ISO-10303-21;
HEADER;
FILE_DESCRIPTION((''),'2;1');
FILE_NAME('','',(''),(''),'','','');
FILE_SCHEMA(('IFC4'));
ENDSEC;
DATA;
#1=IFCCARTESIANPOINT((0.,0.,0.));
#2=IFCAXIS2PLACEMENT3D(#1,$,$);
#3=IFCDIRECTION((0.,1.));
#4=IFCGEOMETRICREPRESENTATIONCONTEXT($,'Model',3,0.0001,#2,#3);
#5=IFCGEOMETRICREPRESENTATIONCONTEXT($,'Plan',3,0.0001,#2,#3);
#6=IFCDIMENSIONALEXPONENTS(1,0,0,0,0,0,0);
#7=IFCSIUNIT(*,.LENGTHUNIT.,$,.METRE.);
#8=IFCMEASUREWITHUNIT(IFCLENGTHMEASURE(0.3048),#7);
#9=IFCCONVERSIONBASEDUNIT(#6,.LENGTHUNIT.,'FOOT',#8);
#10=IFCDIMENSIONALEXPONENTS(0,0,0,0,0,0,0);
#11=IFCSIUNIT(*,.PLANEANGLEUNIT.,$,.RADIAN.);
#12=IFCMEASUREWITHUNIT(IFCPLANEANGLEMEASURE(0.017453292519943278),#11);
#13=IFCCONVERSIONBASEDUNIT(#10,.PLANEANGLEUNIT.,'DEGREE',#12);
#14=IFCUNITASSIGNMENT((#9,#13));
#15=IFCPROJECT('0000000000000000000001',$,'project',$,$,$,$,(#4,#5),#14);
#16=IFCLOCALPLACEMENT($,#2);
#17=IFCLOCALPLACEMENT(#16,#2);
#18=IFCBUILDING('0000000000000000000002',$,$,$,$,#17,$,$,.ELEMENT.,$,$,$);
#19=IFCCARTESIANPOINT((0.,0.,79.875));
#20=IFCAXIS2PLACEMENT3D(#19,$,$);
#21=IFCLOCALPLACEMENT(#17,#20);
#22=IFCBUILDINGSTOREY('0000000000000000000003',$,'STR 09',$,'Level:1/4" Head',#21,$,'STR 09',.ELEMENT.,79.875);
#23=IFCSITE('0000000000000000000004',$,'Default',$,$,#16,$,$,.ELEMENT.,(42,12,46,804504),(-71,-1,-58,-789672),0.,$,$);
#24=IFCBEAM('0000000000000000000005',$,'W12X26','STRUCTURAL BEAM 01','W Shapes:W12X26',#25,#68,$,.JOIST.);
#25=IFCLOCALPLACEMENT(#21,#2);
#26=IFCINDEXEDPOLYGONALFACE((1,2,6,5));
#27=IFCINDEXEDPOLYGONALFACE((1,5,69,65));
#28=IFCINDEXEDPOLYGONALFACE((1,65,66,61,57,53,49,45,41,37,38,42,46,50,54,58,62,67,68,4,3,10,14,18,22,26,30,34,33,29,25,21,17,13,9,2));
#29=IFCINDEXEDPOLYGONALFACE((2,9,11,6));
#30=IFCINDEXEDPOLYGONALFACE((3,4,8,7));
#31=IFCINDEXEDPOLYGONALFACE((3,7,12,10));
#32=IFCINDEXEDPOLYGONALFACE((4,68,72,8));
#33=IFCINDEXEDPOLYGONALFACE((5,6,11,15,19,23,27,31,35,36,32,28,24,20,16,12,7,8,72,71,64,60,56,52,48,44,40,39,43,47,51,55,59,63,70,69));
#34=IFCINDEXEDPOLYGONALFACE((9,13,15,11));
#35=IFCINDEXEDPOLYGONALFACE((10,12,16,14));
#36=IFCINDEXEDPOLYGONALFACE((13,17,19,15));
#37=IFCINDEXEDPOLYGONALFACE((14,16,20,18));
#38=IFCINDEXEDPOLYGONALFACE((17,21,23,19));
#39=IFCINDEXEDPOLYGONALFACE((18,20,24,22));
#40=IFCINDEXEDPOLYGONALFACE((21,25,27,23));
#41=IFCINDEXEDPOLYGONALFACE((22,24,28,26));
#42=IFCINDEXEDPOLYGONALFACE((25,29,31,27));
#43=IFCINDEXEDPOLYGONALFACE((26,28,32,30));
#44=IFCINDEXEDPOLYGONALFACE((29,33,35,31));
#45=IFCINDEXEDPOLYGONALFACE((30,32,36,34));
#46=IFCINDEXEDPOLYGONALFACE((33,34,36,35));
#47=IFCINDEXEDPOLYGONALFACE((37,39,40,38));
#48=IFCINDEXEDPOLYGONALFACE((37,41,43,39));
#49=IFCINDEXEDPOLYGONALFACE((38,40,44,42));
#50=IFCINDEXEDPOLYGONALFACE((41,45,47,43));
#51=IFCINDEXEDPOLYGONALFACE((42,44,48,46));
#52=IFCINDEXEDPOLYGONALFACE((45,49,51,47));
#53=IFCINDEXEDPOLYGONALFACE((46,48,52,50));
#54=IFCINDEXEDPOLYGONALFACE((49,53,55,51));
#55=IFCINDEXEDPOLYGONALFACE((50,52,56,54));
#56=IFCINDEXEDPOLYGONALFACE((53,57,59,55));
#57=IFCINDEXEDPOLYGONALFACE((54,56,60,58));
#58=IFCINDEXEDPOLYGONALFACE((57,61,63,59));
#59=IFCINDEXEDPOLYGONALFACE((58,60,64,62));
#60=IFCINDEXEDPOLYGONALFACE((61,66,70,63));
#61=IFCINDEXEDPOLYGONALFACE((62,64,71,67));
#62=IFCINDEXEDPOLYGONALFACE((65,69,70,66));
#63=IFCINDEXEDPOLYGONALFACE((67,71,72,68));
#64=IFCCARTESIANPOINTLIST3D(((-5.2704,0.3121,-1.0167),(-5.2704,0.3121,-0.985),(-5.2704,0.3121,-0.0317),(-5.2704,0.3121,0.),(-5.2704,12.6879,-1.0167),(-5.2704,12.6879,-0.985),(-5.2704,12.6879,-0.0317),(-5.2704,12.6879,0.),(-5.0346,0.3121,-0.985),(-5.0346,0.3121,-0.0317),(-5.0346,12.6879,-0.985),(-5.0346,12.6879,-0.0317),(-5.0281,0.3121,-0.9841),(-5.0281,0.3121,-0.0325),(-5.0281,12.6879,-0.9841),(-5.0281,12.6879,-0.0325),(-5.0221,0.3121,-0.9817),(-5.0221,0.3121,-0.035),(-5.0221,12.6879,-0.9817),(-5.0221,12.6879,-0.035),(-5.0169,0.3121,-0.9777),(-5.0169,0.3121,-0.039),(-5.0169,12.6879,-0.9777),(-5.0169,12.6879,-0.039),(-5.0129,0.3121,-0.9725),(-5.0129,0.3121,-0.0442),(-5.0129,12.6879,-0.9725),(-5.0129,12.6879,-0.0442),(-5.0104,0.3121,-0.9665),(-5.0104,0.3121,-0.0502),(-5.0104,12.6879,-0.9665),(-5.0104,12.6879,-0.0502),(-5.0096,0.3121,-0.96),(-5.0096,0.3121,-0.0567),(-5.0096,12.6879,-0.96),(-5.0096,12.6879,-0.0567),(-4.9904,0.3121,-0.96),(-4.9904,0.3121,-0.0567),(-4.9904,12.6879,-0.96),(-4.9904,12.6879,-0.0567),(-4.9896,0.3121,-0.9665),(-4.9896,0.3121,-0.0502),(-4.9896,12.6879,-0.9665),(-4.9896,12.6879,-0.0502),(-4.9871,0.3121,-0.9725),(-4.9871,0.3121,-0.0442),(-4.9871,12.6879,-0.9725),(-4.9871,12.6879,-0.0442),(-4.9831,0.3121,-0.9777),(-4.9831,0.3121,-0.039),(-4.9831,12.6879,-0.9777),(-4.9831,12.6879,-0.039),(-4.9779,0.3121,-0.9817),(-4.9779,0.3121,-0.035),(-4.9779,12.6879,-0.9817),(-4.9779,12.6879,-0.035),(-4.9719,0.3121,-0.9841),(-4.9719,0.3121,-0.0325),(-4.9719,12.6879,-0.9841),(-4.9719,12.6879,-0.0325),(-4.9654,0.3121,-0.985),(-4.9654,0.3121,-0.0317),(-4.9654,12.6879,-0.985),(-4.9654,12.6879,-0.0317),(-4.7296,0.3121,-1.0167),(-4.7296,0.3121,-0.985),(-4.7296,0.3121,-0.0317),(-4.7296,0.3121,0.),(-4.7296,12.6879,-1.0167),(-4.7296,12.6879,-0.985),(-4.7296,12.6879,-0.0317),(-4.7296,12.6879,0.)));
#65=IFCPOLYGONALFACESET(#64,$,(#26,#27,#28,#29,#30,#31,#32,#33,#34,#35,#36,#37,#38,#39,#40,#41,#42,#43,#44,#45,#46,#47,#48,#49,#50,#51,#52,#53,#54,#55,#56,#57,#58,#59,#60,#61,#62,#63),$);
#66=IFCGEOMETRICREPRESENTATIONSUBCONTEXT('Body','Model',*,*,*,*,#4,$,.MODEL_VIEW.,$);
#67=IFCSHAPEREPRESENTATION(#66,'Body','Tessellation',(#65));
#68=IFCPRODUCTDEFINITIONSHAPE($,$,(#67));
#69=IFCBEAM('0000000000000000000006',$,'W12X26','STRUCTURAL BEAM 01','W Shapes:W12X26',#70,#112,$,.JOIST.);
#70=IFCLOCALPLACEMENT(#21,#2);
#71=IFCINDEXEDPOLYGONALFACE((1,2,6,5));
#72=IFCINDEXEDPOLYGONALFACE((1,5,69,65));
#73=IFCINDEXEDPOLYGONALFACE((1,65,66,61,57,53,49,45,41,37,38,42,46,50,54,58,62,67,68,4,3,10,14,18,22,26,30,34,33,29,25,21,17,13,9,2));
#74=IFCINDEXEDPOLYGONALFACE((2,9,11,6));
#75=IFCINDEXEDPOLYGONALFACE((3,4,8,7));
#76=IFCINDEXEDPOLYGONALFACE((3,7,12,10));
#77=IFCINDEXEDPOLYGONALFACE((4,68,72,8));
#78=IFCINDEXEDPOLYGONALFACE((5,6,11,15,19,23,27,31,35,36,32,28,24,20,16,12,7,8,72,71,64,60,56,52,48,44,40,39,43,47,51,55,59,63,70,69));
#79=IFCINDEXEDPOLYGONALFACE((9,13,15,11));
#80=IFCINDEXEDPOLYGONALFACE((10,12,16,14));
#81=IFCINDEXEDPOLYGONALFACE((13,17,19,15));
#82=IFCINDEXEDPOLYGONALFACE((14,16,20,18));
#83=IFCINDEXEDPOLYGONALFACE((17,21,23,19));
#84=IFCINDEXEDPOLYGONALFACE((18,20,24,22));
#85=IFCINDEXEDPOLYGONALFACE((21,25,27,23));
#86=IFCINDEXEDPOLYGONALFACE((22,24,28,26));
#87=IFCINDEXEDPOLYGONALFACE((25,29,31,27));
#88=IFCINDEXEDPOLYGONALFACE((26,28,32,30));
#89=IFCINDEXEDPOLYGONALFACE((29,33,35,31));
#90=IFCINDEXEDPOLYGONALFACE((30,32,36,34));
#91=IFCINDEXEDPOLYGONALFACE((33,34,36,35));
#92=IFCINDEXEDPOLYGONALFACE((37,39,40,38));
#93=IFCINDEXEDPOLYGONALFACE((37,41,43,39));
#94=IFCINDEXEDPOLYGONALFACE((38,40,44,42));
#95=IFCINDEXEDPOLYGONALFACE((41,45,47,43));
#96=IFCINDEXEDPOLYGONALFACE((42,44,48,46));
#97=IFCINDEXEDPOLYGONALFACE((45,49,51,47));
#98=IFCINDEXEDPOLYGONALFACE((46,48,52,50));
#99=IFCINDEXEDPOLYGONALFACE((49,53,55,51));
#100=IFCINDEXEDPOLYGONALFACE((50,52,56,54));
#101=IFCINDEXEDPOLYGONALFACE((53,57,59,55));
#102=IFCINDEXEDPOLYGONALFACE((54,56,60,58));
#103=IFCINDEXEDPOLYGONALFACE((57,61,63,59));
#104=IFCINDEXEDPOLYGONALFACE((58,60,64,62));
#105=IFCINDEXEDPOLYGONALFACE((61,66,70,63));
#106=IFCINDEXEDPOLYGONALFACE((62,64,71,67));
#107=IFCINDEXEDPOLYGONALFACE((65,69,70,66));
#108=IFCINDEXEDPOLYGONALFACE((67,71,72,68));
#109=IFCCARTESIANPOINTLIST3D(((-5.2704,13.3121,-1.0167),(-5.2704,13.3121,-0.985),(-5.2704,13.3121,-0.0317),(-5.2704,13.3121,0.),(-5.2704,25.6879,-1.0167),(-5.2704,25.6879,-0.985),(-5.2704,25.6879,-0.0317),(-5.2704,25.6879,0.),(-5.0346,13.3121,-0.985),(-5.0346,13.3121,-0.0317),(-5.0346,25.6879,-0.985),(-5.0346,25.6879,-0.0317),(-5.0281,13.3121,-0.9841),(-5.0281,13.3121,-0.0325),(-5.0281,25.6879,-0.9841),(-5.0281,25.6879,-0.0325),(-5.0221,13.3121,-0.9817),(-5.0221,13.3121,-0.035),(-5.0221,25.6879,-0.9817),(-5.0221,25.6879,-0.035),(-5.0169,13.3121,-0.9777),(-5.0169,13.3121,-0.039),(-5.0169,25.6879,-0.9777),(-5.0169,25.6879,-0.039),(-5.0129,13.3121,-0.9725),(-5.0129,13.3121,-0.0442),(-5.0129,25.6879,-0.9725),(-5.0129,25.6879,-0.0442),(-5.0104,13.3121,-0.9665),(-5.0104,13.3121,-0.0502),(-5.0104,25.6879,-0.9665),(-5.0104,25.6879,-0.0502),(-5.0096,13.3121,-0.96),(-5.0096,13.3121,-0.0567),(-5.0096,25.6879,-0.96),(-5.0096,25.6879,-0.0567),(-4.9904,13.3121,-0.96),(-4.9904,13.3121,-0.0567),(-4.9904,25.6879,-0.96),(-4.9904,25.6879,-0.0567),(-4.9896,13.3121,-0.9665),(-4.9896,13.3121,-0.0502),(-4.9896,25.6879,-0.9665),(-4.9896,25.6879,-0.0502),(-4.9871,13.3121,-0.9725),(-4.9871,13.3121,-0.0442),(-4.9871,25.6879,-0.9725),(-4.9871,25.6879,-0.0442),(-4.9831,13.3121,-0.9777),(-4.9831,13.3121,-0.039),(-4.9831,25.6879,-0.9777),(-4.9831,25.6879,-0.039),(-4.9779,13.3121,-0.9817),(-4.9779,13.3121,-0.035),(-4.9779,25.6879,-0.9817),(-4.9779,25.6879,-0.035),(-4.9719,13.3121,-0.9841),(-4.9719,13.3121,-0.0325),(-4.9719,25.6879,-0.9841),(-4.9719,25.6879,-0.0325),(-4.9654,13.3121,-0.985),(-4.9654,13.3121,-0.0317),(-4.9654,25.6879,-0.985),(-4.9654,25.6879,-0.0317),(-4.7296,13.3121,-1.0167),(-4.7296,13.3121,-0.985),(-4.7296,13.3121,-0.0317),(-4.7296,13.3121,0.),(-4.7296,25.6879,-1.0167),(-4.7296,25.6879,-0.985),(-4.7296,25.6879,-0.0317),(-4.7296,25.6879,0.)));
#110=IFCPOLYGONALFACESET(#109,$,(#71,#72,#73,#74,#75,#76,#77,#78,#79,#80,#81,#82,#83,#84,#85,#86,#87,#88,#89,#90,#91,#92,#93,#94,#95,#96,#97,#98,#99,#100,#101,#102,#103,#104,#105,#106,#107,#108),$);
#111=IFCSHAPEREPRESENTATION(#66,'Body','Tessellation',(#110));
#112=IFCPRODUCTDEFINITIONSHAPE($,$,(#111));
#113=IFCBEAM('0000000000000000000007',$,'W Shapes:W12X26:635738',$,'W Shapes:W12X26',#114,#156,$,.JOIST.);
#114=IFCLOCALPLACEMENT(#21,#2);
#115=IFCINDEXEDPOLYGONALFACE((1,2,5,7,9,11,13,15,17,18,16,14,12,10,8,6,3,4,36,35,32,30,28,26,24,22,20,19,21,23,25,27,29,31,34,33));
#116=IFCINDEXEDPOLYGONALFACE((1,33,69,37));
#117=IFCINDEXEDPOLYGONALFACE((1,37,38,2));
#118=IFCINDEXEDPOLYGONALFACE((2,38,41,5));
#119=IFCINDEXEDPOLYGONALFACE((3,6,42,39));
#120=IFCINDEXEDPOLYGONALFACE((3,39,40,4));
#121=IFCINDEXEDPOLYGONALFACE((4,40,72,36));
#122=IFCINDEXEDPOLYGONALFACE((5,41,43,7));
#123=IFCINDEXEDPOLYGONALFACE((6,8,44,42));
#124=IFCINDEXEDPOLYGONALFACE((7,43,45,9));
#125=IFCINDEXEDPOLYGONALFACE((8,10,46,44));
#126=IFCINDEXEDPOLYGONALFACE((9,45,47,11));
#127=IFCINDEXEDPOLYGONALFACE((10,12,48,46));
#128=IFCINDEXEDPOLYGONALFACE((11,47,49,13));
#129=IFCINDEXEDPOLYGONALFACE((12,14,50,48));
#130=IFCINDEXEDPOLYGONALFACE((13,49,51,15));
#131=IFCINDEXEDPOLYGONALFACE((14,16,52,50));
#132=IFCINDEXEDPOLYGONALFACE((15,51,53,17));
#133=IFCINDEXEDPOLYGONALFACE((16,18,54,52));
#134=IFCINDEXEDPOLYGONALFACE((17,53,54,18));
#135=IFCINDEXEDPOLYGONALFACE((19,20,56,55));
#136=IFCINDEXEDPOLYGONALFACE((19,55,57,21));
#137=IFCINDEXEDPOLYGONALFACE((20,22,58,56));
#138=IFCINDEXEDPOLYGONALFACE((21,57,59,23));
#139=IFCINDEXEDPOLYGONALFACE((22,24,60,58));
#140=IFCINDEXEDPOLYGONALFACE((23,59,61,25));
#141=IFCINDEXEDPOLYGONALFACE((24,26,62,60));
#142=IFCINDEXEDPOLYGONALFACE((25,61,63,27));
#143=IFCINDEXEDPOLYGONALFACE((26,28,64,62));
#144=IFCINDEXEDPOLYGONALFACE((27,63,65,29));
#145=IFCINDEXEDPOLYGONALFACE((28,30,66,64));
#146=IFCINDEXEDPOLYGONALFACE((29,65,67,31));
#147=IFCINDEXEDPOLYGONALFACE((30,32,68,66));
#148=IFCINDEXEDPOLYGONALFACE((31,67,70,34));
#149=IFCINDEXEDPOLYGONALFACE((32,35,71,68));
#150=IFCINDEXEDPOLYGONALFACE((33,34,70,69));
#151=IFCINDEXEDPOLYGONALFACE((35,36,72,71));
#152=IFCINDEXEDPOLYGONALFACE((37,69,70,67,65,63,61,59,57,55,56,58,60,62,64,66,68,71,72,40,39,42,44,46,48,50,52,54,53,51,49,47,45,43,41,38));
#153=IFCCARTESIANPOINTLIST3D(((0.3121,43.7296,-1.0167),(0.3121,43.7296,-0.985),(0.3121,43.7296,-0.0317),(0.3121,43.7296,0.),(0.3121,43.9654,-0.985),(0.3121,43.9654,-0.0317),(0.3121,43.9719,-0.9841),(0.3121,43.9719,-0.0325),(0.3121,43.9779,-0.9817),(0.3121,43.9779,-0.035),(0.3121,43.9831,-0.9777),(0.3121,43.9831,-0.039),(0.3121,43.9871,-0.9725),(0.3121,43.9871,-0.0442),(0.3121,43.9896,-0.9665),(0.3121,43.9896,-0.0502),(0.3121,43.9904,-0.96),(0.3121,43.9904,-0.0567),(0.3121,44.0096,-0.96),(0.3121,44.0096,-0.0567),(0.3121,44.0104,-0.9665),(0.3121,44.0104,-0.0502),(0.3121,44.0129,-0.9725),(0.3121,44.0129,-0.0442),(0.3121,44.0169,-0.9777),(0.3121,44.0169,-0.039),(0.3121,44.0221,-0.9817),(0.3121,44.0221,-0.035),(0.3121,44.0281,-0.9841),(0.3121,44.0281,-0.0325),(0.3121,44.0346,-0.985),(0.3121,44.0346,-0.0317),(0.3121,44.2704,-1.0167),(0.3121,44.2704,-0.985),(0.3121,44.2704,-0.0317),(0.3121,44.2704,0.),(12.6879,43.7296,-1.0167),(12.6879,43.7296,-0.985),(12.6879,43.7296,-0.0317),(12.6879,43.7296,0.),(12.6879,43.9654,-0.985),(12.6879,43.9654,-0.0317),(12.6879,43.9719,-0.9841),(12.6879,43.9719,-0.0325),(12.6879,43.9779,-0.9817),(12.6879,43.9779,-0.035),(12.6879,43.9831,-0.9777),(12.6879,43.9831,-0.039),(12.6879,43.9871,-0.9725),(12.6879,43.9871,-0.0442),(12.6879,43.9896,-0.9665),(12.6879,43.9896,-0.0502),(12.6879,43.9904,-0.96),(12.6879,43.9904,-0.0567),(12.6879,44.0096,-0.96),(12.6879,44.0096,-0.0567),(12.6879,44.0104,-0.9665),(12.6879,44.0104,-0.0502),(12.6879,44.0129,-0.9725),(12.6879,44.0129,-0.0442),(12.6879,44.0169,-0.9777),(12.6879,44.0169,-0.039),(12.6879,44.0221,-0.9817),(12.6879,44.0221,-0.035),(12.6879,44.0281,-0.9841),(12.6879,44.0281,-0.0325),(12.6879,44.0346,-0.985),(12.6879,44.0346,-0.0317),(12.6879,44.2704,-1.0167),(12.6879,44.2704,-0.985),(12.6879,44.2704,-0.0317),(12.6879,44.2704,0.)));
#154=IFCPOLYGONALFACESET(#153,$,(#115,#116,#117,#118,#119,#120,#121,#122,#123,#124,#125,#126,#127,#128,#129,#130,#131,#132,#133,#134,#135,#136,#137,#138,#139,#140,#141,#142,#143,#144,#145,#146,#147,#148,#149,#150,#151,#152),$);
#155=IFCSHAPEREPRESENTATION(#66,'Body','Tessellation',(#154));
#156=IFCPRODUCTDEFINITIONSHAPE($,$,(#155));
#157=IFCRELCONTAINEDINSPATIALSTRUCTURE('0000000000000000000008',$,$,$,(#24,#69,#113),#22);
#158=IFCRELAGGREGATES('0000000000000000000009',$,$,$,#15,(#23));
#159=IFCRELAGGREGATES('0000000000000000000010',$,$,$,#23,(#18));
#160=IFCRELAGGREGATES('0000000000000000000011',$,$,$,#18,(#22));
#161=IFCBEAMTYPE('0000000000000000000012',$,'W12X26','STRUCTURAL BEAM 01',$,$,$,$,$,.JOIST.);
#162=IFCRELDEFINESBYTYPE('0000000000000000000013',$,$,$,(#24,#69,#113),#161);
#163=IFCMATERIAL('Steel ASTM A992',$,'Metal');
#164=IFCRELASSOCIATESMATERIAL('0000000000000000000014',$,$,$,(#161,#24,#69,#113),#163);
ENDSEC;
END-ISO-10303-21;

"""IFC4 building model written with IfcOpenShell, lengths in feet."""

from ifc_helpers import new_model, entity, si_unit, converted_unit, direction, frame, origin, place, context, subcontext, project, spatial, line, arc, indexed_curve, outline, extrude, source, transform, mapped, material, type_object, type_shapes, element, save


model = new_model("IFC4")

# Units and contexts
model_context = context("Model", 3, precision=0.0001, world=origin(), true_north=direction((0.0, 1.0)))
plan_context = context("Plan", 3, precision=0.0001, world=origin(), true_north=direction((0.0, 1.0)))
body_context = subcontext(model_context, "Body", "Model", "MODEL_VIEW")
ifc_project = project(units=[converted_unit("LENGTHUNIT", "FOOT", entity("IfcLengthMeasure", 0.3048), si_unit("LENGTHUNIT", "METRE"), dimensions=[1, 0, 0, 0, 0, 0, 0]), converted_unit("PLANEANGLEUNIT", "DEGREE", entity("IfcPlaneAngleMeasure", 0.017453292519943278), si_unit("PLANEANGLEUNIT", "RADIAN"), dimensions=[0, 0, 0, 0, 0, 0, 0])], contexts=[model_context, plan_context])

# Site, building, storey
site_placement = place(None, origin())
site = spatial("IfcSite", under=ifc_project, at=site_placement, Name="Default", CompositionType="ELEMENT", RefLatitude=(42, 12, 46, 804504), RefLongitude=(-71, -1, -58, -789672), RefElevation=0.0)
building_placement = place(site_placement, origin())
building = spatial("IfcBuilding", under=site, at=building_placement, CompositionType="ELEMENT")
storey_placement = place(building_placement, frame((0.0, 0.0, 79.875)))
storey = spatial("IfcBuildingStorey", under=building, at=storey_placement, Name="STR 09", ObjectType="Level:1/4\" Head", LongName="STR 09", CompositionType="ELEMENT", Elevation=79.875)

# Beams
ifc_material = material(Name="Steel ASTM A992", Category="Metal")
beam_type_1 = type_object("IfcBeamType", Name="W12X26", Description="STRUCTURAL BEAM 01", PredefinedType="JOIST", material=ifc_material)
shared_shape_1 = source(origin(), body_context, "Body", "SweptSolid", [
    extrude(outline(indexed_curve([(-0.2704, -0.4767), (-0.2704, -0.5083), (0.2704, -0.5083), (0.2704, -0.4767), (0.0346, -0.4767), (0.0169, -0.4693), (0.0096, -0.4517), (0.0096, 0.4517), (0.0169, 0.4693), (0.0346, 0.4767), (0.2704, 0.4767), (0.2704, 0.5083), (-0.2704, 0.5083), (-0.2704, 0.4767), (-0.0346, 0.4767), (-0.0169, 0.4693), (-0.0096, 0.4517), (-0.0096, -0.4517), (-0.0169, -0.4693), (-0.0346, -0.4767)], segments=[line(1, 2, 3, 4, 5), arc(5, 6, 7), line(7, 8), arc(8, 9, 10), line(10, 11, 12, 13, 14, 15), arc(15, 16, 17), line(17, 18), arc(18, 19, 20), line(20, 1)], self_intersect=False)), frame((-6.1879, 0.0, 0.0), z_axis=(-1.0, 0.0, 0.0), x_axis=(0.0, -1.0, 0.0)), (0.0, 0.0, -1.0), 12.3758),
])
type_shapes(beam_type_1, [shared_shape_1])
for number, where, z_axis, x_axis, name in (
    (1, (-5.0, 6.5, -0.5083), (0.0, 0.0, 1.0), (0.0, -1.0, 0.0), "W12X26"),
    (2, (-5.0, 19.5, -0.5083), (0.0, 0.0, 1.0), (0.0, 1.0, 0.0), "W12X26"),
):
    element("IfcBeam", number, at=place(storey_placement, frame(where, z_axis=z_axis, x_axis=x_axis)), inside=storey, type_object=beam_type_1, material=ifc_material, Name=name, Description="STRUCTURAL BEAM 01", ObjectType="W Shapes:W12X26", PredefinedType="JOIST", context=body_context, shape_type="MappedRepresentation", body=[
        mapped(shared_shape_1, transform((0.0, 0.0, 0.0), scale=1.0)),
    ])
beam_1_placement = place(storey_placement, frame((6.5, 44.0, -0.5083)))
element("IfcBeam", 3, at=beam_1_placement, inside=storey, type_object=beam_type_1, material=ifc_material, Name="W Shapes:W12X26:635738", ObjectType="W Shapes:W12X26", PredefinedType="JOIST", context=body_context, shape_type="MappedRepresentation", body=[
    mapped(shared_shape_1, transform((0.0, 0.0, 0.0), scale=1.0)),
])

save(model, "model.ifc")
